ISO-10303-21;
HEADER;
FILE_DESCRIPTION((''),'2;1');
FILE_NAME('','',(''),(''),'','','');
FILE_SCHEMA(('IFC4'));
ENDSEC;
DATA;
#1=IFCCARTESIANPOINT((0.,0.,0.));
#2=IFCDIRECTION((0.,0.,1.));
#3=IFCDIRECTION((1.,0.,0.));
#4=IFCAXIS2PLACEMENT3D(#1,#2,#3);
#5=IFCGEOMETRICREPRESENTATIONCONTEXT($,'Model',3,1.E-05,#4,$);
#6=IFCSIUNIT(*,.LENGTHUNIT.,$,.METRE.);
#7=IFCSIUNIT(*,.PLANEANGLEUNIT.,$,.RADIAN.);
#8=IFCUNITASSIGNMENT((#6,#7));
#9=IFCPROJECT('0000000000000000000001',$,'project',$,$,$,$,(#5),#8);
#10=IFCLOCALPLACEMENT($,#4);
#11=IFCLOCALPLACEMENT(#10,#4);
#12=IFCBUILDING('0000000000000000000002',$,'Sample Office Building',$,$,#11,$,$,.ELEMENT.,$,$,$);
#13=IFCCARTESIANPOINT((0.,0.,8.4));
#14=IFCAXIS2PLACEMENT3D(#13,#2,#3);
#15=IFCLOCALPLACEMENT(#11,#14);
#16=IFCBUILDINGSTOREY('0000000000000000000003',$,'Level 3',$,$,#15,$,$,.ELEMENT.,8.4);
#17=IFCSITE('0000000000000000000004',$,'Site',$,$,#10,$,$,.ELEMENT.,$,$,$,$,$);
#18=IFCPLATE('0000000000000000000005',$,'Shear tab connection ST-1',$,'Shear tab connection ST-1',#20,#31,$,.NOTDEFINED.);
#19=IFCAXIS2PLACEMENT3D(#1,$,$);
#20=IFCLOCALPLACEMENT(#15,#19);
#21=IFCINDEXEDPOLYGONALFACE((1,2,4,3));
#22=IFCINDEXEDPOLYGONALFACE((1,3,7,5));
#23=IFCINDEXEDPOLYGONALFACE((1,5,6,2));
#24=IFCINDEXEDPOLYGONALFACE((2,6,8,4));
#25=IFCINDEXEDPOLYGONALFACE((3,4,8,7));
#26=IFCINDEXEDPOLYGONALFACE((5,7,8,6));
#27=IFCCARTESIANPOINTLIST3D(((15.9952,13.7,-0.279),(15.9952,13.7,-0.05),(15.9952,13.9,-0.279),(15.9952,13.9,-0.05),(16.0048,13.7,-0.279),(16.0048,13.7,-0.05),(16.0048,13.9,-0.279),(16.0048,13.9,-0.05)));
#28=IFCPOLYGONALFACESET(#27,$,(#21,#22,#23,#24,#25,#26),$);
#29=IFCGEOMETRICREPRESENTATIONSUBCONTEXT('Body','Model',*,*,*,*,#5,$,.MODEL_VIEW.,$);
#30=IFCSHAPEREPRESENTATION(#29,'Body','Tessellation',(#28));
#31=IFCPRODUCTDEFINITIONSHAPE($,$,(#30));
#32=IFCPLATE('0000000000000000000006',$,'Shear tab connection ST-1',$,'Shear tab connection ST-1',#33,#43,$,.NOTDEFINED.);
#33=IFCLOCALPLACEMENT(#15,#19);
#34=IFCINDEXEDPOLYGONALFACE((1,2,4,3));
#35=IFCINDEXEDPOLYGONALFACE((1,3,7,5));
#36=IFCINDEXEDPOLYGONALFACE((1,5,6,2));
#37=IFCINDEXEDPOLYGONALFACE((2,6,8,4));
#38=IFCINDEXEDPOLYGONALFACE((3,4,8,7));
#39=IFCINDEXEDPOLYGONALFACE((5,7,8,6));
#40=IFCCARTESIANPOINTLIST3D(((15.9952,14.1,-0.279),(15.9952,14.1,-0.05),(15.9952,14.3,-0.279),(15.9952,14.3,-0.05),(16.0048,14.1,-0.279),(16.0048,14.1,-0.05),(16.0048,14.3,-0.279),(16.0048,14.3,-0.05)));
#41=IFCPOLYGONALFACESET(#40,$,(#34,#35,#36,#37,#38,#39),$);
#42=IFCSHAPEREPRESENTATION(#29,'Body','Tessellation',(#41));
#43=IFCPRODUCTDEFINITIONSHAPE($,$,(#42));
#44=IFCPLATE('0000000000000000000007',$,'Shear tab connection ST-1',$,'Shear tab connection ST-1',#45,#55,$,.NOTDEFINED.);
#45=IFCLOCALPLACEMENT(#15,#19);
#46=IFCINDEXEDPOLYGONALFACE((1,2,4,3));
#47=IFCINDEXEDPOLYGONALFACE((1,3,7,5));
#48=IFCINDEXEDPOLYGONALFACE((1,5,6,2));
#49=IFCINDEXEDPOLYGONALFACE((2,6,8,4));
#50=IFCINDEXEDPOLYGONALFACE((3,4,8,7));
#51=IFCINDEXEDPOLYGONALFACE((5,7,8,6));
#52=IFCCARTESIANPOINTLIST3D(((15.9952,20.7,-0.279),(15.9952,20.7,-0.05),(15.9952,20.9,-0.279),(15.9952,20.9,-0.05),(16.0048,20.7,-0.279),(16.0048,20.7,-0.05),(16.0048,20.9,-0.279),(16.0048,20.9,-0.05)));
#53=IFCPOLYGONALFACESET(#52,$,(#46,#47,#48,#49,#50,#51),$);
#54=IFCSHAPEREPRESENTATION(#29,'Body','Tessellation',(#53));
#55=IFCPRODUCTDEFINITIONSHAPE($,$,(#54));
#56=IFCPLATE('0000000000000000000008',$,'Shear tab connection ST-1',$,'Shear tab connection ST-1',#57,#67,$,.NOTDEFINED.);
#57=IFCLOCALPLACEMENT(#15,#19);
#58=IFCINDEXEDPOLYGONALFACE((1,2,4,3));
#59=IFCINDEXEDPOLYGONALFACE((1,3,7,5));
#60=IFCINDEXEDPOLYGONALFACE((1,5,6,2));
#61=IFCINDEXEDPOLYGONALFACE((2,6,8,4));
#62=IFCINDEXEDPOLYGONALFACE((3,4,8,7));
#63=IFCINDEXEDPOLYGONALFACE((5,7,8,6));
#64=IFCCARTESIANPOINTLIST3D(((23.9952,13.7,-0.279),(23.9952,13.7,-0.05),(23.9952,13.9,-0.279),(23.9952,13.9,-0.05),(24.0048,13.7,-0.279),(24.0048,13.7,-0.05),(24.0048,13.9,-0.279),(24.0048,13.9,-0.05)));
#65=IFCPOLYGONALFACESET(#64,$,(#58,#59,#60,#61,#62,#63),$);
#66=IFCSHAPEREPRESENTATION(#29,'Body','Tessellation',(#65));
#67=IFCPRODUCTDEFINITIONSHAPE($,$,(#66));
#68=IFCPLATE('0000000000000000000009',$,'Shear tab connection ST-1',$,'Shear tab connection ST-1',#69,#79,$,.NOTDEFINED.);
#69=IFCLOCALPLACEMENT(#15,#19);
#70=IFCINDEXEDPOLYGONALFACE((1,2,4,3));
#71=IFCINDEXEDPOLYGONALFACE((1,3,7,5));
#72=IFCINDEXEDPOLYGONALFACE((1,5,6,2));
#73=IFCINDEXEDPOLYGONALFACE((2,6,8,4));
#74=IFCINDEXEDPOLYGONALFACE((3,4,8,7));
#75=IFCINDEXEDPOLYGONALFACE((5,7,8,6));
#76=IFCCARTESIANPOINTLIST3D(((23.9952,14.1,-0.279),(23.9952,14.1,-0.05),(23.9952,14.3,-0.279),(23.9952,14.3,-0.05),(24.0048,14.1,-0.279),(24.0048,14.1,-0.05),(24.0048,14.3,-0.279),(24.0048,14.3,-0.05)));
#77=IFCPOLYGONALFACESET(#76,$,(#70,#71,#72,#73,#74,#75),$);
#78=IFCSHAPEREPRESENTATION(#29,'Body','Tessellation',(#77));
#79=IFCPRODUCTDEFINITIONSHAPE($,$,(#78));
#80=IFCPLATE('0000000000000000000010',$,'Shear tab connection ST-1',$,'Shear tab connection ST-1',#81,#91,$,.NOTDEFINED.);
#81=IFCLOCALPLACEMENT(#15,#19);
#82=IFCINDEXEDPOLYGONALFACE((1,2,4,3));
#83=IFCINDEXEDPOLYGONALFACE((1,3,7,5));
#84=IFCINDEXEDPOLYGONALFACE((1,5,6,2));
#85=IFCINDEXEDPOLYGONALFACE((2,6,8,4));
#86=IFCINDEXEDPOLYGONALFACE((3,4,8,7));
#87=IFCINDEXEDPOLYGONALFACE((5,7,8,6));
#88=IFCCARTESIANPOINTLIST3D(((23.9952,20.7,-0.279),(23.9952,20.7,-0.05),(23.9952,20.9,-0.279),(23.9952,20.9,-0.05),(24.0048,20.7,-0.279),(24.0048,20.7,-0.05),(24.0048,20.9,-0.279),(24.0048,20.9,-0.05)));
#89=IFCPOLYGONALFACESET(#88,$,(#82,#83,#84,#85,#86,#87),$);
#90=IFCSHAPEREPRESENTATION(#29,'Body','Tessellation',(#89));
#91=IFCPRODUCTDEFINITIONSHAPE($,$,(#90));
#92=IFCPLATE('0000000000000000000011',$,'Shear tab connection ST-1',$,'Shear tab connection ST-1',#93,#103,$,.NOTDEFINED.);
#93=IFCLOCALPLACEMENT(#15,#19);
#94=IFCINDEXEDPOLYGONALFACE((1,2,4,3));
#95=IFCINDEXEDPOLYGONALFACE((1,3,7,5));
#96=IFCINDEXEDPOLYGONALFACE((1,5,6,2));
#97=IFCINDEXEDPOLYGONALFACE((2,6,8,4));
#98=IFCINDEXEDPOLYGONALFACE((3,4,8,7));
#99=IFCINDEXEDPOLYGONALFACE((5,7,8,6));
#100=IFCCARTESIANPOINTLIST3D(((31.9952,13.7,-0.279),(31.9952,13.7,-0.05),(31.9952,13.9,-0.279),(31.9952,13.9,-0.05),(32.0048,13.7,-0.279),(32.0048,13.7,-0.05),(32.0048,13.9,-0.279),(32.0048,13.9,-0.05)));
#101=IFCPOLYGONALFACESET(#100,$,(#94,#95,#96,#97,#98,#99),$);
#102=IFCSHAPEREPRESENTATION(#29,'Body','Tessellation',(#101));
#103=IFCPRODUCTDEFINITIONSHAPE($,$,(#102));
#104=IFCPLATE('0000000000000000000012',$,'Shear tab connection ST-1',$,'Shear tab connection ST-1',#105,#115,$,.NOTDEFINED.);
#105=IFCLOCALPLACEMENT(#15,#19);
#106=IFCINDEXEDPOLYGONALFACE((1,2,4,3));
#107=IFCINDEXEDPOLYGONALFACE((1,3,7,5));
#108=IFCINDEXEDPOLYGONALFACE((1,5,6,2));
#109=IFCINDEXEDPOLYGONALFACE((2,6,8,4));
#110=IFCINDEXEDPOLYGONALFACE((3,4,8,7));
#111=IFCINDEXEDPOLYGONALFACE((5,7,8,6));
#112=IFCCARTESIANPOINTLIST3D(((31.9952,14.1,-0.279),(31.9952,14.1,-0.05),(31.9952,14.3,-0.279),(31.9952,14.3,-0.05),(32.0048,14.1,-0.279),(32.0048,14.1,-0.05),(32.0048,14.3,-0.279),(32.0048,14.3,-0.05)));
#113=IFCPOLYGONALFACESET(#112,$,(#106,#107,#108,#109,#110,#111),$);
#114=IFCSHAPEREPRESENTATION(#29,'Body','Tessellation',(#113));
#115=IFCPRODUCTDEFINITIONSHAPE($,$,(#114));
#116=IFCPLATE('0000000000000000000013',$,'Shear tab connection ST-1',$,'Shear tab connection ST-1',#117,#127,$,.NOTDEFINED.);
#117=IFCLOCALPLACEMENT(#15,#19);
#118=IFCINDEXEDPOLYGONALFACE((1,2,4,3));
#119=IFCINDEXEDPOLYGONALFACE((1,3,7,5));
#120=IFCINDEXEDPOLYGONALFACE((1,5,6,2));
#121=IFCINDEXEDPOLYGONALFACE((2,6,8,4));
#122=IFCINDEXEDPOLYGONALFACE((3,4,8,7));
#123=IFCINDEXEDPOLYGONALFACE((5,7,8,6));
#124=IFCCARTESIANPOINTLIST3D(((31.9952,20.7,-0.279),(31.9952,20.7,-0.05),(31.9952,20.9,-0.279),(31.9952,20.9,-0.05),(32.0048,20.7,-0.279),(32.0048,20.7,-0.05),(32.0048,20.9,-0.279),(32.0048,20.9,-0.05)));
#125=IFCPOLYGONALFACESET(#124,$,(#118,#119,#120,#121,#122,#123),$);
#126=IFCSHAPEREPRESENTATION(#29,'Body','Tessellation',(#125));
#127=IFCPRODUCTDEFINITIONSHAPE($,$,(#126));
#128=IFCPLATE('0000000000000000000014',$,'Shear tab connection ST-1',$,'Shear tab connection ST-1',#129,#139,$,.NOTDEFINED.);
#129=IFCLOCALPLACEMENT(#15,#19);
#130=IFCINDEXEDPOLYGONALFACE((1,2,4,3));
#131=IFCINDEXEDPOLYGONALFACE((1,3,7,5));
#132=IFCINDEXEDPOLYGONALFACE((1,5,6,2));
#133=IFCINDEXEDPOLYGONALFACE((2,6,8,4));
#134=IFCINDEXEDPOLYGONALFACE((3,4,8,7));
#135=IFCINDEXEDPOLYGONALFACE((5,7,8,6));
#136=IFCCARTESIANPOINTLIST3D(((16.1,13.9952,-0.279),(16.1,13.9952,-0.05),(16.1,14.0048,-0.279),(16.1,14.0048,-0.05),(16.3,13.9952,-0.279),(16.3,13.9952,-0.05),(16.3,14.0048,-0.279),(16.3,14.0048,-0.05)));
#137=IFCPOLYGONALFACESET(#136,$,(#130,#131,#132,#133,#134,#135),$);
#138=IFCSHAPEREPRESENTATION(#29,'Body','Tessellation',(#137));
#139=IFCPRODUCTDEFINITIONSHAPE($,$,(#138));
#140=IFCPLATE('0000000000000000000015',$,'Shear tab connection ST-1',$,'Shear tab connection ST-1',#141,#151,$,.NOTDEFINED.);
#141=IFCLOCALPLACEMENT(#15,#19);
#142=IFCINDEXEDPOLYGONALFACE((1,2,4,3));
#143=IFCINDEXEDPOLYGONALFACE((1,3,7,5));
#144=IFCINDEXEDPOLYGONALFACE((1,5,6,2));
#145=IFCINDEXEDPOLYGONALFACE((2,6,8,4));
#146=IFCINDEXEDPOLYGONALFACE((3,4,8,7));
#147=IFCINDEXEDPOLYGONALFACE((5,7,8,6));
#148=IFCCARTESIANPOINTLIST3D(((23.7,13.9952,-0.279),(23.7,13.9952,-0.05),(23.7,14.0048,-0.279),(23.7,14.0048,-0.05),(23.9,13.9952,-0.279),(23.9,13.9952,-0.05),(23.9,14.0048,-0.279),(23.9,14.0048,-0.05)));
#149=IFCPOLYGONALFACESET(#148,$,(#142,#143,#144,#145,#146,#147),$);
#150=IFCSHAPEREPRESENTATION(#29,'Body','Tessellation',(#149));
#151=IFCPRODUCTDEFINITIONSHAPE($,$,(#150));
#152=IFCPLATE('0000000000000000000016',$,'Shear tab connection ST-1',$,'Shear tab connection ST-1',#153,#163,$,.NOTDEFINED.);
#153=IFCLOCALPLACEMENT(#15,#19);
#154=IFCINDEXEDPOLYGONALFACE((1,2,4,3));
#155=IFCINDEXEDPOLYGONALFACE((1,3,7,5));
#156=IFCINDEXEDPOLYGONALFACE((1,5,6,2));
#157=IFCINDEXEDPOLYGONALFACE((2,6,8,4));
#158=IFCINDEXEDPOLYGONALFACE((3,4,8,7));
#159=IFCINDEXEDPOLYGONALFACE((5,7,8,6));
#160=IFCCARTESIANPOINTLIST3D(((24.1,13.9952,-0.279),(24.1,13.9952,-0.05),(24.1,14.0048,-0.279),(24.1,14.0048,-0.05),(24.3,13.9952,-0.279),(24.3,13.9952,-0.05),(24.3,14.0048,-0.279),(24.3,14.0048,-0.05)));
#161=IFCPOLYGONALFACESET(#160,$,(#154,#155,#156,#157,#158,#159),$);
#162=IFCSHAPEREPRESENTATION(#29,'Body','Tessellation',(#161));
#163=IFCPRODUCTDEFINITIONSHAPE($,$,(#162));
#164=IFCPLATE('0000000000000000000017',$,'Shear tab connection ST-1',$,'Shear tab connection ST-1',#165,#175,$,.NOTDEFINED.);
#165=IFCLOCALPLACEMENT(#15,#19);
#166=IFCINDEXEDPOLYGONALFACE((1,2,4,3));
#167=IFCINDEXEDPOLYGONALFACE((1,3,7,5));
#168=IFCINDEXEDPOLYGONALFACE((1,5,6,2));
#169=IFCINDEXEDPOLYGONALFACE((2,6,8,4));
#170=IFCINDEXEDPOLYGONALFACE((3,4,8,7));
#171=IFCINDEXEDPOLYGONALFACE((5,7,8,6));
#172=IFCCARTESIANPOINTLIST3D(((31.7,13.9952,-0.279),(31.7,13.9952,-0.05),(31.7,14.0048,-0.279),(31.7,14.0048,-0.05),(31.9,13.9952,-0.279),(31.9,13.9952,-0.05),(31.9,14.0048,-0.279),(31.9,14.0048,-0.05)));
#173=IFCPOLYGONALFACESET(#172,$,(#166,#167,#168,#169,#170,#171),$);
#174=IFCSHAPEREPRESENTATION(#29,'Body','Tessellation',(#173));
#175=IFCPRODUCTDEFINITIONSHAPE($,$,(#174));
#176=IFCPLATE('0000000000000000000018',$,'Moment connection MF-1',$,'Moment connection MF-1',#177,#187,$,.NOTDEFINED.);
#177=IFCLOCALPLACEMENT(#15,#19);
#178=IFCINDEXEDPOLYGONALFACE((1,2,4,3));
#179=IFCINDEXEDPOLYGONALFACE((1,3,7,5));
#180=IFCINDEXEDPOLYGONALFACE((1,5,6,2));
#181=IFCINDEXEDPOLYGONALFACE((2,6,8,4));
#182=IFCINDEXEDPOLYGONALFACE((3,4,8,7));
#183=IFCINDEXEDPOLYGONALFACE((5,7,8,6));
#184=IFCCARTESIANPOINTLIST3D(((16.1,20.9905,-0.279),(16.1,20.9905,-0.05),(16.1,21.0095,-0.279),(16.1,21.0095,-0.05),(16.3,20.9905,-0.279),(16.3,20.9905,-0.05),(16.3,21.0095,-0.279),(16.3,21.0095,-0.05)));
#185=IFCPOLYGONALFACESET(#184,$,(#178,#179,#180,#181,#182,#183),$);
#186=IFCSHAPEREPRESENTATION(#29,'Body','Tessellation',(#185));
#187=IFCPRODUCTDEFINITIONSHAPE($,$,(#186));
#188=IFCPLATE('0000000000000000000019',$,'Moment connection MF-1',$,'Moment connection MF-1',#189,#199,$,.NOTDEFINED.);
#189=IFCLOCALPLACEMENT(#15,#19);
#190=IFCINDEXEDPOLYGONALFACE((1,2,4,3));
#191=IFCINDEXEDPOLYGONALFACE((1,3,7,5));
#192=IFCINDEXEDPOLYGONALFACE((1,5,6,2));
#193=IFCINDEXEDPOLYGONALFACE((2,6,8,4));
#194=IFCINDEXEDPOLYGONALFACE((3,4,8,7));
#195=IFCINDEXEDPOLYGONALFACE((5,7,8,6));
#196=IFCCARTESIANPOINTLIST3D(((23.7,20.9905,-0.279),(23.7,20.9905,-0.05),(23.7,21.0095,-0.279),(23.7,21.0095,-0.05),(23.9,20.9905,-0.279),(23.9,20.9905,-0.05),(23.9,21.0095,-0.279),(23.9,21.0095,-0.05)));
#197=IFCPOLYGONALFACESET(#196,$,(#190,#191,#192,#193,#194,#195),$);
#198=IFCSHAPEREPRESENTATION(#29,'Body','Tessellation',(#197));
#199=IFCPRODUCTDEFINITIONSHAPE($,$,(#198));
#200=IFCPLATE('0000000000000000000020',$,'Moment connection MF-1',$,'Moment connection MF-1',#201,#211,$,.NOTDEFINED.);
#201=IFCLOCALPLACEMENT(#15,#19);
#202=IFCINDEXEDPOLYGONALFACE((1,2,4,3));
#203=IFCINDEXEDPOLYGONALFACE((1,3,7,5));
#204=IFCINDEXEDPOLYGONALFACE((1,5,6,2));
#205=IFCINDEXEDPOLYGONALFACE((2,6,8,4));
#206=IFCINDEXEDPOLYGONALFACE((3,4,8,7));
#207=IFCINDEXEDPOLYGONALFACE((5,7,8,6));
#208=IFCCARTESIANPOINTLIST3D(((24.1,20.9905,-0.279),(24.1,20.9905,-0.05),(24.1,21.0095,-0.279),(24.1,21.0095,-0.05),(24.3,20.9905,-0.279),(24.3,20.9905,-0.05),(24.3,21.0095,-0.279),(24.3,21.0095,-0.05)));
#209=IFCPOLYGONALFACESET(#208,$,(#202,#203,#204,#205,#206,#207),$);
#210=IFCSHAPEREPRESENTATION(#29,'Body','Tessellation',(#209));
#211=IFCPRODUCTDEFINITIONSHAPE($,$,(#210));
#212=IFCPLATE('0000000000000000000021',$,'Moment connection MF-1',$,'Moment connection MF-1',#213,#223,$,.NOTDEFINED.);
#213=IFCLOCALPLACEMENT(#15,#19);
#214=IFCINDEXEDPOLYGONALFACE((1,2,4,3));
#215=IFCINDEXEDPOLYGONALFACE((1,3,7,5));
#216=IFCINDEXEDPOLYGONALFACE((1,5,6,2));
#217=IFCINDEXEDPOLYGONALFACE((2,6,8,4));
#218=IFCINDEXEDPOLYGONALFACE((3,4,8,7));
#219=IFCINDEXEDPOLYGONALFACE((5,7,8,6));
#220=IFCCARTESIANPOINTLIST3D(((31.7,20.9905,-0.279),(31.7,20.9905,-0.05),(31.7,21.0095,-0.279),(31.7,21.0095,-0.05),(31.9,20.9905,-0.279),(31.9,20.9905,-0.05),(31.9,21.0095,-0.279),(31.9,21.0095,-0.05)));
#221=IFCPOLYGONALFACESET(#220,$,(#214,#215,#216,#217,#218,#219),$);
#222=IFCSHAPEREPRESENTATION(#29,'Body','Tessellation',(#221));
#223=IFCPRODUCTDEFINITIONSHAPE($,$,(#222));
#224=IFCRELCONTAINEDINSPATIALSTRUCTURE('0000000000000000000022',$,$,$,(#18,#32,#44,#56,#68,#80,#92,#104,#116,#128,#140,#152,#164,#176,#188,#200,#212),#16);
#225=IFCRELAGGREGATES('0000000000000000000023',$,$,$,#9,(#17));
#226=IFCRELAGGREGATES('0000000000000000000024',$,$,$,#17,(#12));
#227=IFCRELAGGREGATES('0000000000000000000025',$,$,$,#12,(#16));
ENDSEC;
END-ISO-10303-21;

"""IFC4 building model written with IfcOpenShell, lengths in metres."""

from ifc_helpers import new_model, si_unit, frame, origin_with_axes, place, context, subcontext, project, spatial, rectangle, extrude, element, save


model = new_model("IFC4")

# Units and contexts
model_context = context("Model", 3, precision=1e-05, world=origin_with_axes())
body_context = subcontext(model_context, "Body", "Model", "MODEL_VIEW")
ifc_project = project(units=[si_unit("LENGTHUNIT", "METRE"), si_unit("PLANEANGLEUNIT", "RADIAN")], contexts=[model_context])

# Site, building, storey
site_placement = place(None, origin_with_axes())
site = spatial("IfcSite", under=ifc_project, at=site_placement, Name="Site", CompositionType="ELEMENT")
building_placement = place(site_placement, origin_with_axes())
building = spatial("IfcBuilding", under=site, at=building_placement, Name="Sample Office Building", CompositionType="ELEMENT")
storey_placement = place(building_placement, frame((0.0, 0.0, 8.4), z_axis=(0.0, 0.0, 1.0), x_axis=(1.0, 0.0, 0.0)))
storey = spatial("IfcBuildingStorey", under=building, at=storey_placement, Name="Level 3", CompositionType="ELEMENT", Elevation=8.4)

# Plates
for number, where, z_axis, x_axis, name in (
    (1, (16.0, 13.8, 8.121), (0.0, 0.0, 1.0), (1.0, 0.0, 0.0), "Shear tab connection ST-1"),
    (2, (16.0, 14.2, 8.121), (0.0, 0.0, 1.0), (1.0, 0.0, 0.0), "Shear tab connection ST-1"),
):
    element("IfcPlate", number, at=place(None, frame(where, z_axis=z_axis, x_axis=x_axis)), inside=storey, Name=name, ObjectType="Shear tab connection ST-1", PredefinedType="NOTDEFINED", context=body_context, shape_type="SweptSolid", body=[
        extrude(rectangle(XDim=0.0095, YDim=0.2), None, (0.0, 0.0, 1.0), 0.229),
    ])
plate_1_placement = place(None, frame((16.0, 20.8, 8.121), z_axis=(0.0, 0.0, 1.0), x_axis=(1.0, 0.0, 0.0)))
element("IfcPlate", 3, at=plate_1_placement, inside=storey, Name="Shear tab connection ST-1", ObjectType="Shear tab connection ST-1", PredefinedType="NOTDEFINED", context=body_context, shape_type="SweptSolid", body=[
    extrude(rectangle(XDim=0.0095, YDim=0.2), None, (0.0, 0.0, 1.0), 0.229),
])
for number, where, z_axis, x_axis, name in (
    (4, (24.0, 13.8, 8.121), (0.0, 0.0, 1.0), (1.0, 0.0, 0.0), "Shear tab connection ST-1"),
    (5, (24.0, 14.2, 8.121), (0.0, 0.0, 1.0), (1.0, 0.0, 0.0), "Shear tab connection ST-1"),
):
    element("IfcPlate", number, at=place(None, frame(where, z_axis=z_axis, x_axis=x_axis)), inside=storey, Name=name, ObjectType="Shear tab connection ST-1", PredefinedType="NOTDEFINED", context=body_context, shape_type="SweptSolid", body=[
        extrude(rectangle(XDim=0.0095, YDim=0.2), None, (0.0, 0.0, 1.0), 0.229),
    ])
plate_2_placement = place(None, frame((24.0, 20.8, 8.121), z_axis=(0.0, 0.0, 1.0), x_axis=(1.0, 0.0, 0.0)))
element("IfcPlate", 6, at=plate_2_placement, inside=storey, Name="Shear tab connection ST-1", ObjectType="Shear tab connection ST-1", PredefinedType="NOTDEFINED", context=body_context, shape_type="SweptSolid", body=[
    extrude(rectangle(XDim=0.0095, YDim=0.2), None, (0.0, 0.0, 1.0), 0.229),
])
for number, where, z_axis, x_axis, name in (
    (7, (32.0, 13.8, 8.121), (0.0, 0.0, 1.0), (1.0, 0.0, 0.0), "Shear tab connection ST-1"),
    (8, (32.0, 14.2, 8.121), (0.0, 0.0, 1.0), (1.0, 0.0, 0.0), "Shear tab connection ST-1"),
):
    element("IfcPlate", number, at=place(None, frame(where, z_axis=z_axis, x_axis=x_axis)), inside=storey, Name=name, ObjectType="Shear tab connection ST-1", PredefinedType="NOTDEFINED", context=body_context, shape_type="SweptSolid", body=[
        extrude(rectangle(XDim=0.0095, YDim=0.2), None, (0.0, 0.0, 1.0), 0.229),
    ])
plate_3_placement = place(None, frame((32.0, 20.8, 8.121), z_axis=(0.0, 0.0, 1.0), x_axis=(1.0, 0.0, 0.0)))
element("IfcPlate", 9, at=plate_3_placement, inside=storey, Name="Shear tab connection ST-1", ObjectType="Shear tab connection ST-1", PredefinedType="NOTDEFINED", context=body_context, shape_type="SweptSolid", body=[
    extrude(rectangle(XDim=0.0095, YDim=0.2), None, (0.0, 0.0, 1.0), 0.229),
])
for number, where, z_axis, x_axis, name in (
    (10, (16.2, 14.0, 8.121), (0.0, 0.0, 1.0), (1.0, 0.0, 0.0), "Shear tab connection ST-1"),
    (11, (23.8, 14.0, 8.121), (0.0, 0.0, 1.0), (1.0, 0.0, 0.0), "Shear tab connection ST-1"),
    (12, (24.2, 14.0, 8.121), (0.0, 0.0, 1.0), (1.0, 0.0, 0.0), "Shear tab connection ST-1"),
    (13, (31.8, 14.0, 8.121), (0.0, 0.0, 1.0), (1.0, 0.0, 0.0), "Shear tab connection ST-1"),
):
    element("IfcPlate", number, at=place(None, frame(where, z_axis=z_axis, x_axis=x_axis)), inside=storey, Name=name, ObjectType="Shear tab connection ST-1", PredefinedType="NOTDEFINED", context=body_context, shape_type="SweptSolid", body=[
        extrude(rectangle(XDim=0.2, YDim=0.0095), None, (0.0, 0.0, 1.0), 0.229),
    ])
for number, where, z_axis, x_axis, name in (
    (14, (16.2, 21.0, 8.121), (0.0, 0.0, 1.0), (1.0, 0.0, 0.0), "Moment connection MF-1"),
    (15, (23.8, 21.0, 8.121), (0.0, 0.0, 1.0), (1.0, 0.0, 0.0), "Moment connection MF-1"),
    (16, (24.2, 21.0, 8.121), (0.0, 0.0, 1.0), (1.0, 0.0, 0.0), "Moment connection MF-1"),
    (17, (31.8, 21.0, 8.121), (0.0, 0.0, 1.0), (1.0, 0.0, 0.0), "Moment connection MF-1"),
):
    element("IfcPlate", number, at=place(None, frame(where, z_axis=z_axis, x_axis=x_axis)), inside=storey, Name=name, ObjectType="Moment connection MF-1", PredefinedType="NOTDEFINED", context=body_context, shape_type="SweptSolid", body=[
        extrude(rectangle(XDim=0.2, YDim=0.019), None, (0.0, 0.0, 1.0), 0.229),
    ])

save(model, "model.ifc")
